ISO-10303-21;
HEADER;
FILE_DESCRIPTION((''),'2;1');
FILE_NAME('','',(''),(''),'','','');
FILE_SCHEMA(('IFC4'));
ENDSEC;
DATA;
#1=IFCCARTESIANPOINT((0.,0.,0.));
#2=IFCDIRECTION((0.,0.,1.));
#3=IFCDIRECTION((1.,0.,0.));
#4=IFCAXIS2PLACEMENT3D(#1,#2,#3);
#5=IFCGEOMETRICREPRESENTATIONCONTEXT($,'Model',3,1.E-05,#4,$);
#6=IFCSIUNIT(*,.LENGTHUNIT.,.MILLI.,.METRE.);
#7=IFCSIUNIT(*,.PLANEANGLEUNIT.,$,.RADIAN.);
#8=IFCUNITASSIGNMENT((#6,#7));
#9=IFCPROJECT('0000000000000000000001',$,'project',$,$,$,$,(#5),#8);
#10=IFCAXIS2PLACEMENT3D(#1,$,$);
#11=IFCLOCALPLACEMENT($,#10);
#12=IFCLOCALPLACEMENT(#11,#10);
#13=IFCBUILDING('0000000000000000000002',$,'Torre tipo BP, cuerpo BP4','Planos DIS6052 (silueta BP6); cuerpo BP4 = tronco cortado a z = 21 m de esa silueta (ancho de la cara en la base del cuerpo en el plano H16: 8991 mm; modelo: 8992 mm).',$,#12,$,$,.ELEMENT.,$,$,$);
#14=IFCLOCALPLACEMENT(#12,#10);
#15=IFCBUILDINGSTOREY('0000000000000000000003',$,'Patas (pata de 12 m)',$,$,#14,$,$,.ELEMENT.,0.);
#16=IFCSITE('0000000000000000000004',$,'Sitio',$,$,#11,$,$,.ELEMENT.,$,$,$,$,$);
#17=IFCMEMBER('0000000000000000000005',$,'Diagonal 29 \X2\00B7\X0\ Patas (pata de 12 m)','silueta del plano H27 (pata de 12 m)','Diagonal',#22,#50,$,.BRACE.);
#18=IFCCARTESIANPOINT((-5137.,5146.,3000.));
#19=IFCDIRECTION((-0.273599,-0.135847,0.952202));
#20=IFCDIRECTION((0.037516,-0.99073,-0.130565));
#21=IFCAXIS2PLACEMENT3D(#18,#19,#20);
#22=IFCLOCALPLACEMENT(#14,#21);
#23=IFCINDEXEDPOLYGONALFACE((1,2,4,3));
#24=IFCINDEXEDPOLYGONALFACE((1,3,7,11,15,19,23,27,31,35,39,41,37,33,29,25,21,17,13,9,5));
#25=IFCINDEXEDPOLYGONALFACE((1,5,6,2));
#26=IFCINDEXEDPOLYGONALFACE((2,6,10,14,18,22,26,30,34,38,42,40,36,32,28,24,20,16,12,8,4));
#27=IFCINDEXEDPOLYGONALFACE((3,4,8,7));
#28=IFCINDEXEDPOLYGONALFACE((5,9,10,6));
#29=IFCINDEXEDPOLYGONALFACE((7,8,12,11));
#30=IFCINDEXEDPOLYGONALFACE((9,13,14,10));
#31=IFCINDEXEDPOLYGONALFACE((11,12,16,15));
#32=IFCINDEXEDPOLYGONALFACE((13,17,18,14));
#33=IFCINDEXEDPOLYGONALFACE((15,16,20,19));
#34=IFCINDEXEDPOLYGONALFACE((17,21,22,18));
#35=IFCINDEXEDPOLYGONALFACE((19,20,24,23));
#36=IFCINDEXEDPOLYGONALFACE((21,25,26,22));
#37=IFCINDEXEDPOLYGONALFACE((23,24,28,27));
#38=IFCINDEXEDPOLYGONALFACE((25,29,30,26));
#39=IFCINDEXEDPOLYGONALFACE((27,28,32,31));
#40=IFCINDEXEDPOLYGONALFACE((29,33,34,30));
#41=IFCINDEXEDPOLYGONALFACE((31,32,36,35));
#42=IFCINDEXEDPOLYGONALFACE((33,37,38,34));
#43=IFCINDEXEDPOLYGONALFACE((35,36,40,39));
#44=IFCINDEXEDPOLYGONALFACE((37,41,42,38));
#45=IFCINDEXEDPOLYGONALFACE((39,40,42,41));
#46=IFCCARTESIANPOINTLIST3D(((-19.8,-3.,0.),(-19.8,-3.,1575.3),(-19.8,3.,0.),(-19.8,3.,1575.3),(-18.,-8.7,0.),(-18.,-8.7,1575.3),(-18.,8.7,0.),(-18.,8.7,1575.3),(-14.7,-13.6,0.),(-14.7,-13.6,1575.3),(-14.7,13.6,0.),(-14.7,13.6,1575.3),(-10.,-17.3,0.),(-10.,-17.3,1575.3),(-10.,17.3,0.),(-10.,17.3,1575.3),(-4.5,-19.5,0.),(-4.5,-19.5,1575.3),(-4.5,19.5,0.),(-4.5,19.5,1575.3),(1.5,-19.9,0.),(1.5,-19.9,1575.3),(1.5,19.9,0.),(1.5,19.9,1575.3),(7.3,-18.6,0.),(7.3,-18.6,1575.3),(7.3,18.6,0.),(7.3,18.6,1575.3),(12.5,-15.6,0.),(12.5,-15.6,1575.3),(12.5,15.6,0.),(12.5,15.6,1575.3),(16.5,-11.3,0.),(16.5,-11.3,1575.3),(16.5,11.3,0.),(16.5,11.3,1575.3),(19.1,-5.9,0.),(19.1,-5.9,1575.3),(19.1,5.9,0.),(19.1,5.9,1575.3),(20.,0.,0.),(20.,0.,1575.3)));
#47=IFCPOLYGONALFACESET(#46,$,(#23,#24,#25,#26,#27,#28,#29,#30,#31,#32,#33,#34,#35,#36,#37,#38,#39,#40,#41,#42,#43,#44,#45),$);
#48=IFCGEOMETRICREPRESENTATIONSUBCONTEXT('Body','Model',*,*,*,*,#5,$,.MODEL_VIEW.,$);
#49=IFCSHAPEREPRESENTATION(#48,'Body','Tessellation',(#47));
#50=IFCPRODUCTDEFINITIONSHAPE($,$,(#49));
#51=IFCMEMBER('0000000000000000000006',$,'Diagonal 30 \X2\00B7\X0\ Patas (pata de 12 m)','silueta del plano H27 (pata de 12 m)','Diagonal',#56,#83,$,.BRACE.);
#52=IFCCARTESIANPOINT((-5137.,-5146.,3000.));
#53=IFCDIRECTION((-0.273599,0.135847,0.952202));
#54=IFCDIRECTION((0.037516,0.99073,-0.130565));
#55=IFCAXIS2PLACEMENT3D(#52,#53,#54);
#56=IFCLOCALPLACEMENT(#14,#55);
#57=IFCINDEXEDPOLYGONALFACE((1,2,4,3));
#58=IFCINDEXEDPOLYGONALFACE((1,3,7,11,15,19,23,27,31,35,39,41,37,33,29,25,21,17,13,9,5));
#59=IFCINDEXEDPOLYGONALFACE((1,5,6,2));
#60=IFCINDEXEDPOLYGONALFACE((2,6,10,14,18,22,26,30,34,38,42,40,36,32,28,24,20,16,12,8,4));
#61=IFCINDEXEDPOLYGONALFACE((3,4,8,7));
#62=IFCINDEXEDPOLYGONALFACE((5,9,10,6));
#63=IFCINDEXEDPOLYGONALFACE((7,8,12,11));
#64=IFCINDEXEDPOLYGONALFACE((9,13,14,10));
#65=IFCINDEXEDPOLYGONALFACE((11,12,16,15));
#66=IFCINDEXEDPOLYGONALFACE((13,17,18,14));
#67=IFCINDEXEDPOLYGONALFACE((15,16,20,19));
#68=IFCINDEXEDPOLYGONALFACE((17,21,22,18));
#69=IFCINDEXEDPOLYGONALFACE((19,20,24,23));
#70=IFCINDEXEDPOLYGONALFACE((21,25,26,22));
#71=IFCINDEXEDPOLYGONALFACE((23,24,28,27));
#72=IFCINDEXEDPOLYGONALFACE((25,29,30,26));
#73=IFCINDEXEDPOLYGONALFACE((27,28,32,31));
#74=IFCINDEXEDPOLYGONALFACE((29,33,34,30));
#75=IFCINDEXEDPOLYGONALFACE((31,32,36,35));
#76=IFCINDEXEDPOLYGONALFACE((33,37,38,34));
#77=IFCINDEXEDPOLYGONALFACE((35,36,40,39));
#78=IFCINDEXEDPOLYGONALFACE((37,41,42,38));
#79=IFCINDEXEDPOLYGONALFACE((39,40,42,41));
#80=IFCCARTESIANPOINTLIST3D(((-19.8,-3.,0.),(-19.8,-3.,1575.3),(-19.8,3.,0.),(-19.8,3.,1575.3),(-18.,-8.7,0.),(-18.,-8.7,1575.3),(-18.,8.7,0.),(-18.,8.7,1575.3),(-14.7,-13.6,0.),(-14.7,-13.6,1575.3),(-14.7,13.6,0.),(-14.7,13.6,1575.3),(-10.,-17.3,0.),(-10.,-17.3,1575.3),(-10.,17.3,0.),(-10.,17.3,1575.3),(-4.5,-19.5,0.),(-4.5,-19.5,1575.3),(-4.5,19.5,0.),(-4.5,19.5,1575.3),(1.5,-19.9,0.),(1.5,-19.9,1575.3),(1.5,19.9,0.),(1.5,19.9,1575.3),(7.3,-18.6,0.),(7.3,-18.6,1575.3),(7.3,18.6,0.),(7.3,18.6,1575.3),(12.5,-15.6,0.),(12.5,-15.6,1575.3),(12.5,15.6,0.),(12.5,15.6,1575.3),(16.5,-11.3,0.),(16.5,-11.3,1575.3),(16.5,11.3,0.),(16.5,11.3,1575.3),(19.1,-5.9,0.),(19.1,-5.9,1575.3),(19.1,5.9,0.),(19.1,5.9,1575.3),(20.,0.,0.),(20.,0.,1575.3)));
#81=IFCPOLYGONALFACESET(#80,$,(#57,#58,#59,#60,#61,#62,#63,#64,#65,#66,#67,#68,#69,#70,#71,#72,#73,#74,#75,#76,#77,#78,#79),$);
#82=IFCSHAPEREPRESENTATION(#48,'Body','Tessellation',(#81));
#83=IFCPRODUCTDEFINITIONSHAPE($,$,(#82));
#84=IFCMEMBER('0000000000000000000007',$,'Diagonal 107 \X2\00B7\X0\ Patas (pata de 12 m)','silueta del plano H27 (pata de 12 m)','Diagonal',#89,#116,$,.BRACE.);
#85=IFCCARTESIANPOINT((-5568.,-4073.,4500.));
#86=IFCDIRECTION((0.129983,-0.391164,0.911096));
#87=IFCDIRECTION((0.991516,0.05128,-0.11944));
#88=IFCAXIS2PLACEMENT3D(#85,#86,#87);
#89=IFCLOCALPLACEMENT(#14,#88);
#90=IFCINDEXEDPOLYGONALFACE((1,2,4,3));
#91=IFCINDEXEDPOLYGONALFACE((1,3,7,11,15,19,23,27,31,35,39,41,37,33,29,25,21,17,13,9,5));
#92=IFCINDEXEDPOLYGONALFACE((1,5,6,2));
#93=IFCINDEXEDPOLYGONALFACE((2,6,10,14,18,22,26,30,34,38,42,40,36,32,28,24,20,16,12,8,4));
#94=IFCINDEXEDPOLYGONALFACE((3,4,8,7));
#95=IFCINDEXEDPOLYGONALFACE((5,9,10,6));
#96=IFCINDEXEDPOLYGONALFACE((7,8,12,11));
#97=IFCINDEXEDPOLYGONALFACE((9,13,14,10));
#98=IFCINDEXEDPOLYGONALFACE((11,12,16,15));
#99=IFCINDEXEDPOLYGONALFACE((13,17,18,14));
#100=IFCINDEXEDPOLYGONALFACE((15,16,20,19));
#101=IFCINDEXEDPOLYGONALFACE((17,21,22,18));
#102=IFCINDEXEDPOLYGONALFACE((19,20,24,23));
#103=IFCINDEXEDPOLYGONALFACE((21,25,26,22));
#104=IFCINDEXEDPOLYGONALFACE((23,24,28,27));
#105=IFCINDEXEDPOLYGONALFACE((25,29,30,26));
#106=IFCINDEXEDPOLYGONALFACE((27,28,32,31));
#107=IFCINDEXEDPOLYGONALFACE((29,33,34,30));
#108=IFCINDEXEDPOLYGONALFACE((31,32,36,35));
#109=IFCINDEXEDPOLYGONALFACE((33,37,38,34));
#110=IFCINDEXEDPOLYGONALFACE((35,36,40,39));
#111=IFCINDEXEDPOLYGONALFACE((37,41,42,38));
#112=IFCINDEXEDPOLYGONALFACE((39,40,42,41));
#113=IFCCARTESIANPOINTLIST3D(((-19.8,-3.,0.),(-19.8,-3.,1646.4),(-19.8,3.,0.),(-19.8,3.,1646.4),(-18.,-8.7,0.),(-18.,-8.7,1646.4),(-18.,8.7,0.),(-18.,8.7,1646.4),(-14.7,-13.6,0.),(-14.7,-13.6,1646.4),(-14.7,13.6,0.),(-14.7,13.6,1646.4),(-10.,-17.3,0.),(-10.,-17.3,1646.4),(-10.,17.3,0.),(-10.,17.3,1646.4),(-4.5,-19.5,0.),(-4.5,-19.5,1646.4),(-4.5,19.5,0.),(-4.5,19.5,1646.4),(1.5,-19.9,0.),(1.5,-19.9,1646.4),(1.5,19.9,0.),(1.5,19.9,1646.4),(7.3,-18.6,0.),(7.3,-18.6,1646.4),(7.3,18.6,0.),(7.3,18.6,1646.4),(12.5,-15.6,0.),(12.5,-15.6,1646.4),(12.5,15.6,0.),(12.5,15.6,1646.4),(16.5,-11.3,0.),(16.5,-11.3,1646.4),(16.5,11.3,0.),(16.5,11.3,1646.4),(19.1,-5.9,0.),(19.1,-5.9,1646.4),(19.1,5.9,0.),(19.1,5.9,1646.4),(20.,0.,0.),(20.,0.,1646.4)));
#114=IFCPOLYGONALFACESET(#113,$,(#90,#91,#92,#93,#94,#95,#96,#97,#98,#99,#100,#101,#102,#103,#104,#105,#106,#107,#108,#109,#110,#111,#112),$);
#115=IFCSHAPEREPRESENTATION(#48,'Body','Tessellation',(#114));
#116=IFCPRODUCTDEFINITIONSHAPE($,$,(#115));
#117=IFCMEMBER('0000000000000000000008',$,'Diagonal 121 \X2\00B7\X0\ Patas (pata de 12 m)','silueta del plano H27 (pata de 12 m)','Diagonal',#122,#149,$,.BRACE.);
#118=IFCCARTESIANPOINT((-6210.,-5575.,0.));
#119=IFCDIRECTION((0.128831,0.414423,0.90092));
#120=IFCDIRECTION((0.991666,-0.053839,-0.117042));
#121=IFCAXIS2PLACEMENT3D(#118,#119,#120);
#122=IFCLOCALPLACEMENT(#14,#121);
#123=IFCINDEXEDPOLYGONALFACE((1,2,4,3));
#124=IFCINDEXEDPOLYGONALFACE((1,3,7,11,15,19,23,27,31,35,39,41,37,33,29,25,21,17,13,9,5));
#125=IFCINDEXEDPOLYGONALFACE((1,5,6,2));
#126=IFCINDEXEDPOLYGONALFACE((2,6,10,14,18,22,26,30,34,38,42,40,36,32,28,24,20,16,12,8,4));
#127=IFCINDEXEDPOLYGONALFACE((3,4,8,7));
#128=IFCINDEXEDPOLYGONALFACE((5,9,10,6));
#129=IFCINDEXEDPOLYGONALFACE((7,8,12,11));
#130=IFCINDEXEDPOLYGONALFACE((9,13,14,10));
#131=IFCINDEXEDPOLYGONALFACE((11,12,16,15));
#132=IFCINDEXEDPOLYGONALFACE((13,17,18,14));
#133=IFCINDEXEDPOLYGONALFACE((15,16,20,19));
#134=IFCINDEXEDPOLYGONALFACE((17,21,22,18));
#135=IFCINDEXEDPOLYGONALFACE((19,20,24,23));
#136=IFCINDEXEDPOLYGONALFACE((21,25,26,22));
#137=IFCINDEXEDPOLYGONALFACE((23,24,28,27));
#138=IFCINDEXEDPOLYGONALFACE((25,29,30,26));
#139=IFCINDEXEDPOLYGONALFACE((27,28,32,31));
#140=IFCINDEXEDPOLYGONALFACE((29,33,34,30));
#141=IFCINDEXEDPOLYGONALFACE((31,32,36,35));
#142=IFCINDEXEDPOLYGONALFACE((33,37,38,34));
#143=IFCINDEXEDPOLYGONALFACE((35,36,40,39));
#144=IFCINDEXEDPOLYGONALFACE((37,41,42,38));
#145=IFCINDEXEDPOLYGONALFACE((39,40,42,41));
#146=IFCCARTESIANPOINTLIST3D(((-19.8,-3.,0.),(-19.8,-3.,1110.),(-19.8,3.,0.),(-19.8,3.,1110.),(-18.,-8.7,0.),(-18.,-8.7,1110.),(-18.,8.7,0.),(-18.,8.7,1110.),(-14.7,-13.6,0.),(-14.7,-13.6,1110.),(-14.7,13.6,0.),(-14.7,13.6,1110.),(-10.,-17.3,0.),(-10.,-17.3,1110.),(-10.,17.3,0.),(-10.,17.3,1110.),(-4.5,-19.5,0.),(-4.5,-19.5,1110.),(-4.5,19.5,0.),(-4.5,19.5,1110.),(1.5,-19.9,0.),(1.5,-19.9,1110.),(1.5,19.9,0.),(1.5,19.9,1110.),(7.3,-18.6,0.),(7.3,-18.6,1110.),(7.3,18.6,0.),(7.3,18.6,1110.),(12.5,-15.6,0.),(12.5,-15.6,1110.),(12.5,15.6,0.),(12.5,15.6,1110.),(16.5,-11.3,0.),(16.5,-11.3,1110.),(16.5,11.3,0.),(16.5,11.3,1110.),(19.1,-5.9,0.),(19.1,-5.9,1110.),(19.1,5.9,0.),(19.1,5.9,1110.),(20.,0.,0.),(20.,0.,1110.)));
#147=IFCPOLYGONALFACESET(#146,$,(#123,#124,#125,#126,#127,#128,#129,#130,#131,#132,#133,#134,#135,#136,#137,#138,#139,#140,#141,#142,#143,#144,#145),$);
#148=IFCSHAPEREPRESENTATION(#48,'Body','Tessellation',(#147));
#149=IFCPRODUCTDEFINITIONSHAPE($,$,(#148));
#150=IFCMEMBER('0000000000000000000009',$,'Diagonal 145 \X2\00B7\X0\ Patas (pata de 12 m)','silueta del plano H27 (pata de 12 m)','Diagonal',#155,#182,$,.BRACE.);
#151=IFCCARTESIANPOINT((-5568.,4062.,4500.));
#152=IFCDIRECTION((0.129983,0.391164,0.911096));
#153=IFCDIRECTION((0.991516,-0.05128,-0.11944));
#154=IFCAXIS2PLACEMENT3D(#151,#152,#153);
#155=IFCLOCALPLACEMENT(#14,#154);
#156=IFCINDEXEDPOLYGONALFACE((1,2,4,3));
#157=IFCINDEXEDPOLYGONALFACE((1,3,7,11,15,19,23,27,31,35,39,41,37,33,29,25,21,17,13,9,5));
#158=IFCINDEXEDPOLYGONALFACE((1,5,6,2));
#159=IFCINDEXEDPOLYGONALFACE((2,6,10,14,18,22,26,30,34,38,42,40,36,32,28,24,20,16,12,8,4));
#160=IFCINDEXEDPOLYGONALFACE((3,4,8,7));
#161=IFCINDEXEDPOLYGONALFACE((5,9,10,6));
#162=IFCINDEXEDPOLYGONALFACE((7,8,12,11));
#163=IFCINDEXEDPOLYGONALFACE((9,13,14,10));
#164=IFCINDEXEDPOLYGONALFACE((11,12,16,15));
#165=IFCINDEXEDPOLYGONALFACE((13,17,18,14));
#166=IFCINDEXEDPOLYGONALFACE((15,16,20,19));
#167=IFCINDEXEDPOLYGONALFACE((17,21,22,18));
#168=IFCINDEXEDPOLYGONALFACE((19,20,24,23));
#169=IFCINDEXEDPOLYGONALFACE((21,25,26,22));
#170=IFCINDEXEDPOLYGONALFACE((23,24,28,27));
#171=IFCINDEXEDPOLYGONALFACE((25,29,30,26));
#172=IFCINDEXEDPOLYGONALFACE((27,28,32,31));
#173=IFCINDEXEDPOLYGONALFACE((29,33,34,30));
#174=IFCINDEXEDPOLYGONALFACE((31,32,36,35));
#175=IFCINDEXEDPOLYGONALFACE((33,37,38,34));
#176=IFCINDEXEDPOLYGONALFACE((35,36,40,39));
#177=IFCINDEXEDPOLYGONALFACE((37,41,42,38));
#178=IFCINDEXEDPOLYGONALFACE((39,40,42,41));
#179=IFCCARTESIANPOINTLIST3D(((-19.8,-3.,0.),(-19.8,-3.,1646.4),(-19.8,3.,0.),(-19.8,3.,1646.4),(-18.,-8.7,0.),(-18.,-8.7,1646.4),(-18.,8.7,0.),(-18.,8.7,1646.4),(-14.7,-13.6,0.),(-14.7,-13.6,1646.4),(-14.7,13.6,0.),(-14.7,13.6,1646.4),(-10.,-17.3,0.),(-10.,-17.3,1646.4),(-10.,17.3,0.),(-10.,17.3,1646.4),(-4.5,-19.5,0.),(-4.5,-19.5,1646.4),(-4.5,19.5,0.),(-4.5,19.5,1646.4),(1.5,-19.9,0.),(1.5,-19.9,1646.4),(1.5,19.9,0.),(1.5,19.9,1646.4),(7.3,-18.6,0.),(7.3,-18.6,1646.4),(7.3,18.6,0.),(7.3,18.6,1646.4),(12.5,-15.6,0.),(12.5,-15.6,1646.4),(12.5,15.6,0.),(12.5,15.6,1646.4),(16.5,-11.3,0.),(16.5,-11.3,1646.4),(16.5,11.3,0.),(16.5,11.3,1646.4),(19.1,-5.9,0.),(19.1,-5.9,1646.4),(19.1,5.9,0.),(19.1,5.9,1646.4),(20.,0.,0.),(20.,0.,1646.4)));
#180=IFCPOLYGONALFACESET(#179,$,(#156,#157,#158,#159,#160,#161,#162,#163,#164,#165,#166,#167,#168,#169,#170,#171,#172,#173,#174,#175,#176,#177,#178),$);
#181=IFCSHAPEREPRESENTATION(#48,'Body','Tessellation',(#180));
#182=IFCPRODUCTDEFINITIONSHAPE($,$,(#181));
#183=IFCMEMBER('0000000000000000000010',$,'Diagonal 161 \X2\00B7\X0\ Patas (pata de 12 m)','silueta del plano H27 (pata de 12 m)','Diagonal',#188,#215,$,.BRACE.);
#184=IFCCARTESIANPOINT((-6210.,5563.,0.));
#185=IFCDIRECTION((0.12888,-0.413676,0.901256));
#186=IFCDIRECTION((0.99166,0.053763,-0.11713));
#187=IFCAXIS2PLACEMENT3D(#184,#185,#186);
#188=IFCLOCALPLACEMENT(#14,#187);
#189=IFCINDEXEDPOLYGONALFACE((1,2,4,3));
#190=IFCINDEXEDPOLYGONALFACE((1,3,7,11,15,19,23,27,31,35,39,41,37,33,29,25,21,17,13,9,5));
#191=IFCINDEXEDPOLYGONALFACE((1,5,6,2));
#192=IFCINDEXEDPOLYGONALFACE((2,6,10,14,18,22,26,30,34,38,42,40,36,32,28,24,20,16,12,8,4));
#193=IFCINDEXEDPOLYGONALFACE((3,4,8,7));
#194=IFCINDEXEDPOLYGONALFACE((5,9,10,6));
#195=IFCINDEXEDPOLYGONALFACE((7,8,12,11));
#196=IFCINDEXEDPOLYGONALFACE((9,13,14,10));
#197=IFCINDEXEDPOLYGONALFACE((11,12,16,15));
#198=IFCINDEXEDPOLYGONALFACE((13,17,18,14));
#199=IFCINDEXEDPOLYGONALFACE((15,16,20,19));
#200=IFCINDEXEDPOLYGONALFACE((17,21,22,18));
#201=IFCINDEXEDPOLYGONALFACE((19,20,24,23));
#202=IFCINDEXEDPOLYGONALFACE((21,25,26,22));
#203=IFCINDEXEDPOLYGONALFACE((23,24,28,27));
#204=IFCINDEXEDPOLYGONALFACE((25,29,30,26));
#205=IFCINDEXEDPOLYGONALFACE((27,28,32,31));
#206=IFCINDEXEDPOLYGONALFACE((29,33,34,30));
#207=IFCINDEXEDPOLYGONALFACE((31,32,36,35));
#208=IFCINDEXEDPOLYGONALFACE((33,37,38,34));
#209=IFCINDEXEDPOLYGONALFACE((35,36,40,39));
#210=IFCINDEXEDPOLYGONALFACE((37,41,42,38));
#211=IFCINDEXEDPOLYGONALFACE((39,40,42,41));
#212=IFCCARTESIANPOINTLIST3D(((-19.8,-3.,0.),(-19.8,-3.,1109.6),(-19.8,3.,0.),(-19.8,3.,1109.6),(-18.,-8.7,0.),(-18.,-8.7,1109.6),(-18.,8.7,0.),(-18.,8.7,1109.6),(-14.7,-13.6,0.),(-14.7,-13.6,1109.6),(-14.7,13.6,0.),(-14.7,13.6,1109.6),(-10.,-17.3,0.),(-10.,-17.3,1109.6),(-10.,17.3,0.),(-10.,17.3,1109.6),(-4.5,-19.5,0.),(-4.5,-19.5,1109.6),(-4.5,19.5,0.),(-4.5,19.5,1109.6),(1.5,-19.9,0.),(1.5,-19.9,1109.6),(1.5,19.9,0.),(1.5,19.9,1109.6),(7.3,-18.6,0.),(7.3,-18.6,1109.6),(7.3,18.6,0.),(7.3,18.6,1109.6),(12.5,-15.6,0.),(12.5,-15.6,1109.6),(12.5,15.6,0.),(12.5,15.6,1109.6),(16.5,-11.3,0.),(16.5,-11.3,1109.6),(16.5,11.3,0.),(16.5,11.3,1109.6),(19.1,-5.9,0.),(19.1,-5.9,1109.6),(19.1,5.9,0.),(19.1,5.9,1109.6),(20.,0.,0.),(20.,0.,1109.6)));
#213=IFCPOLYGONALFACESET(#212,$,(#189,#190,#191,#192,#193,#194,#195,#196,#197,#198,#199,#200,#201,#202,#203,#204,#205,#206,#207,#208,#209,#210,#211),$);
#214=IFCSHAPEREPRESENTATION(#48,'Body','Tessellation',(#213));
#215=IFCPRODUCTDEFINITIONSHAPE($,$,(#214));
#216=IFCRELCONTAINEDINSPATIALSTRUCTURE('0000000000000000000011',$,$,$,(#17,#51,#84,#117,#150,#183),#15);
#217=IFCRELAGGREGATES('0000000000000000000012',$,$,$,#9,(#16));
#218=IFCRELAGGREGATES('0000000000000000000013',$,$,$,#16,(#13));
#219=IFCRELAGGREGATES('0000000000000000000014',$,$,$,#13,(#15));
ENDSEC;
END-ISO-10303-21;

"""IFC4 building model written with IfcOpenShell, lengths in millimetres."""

from ifc_helpers import new_model, si_unit, frame, origin, origin_with_axes, place, context, subcontext, project, spatial, circle, extrude, element, save


model = new_model("IFC4")

# Units and contexts
model_context = context("Model", 3, precision=1e-05, world=origin_with_axes())
body_context = subcontext(model_context, "Body", "Model", "MODEL_VIEW")
ifc_project = project(units=[si_unit("LENGTHUNIT", "METRE", prefix="MILLI"), si_unit("PLANEANGLEUNIT", "RADIAN")], contexts=[model_context])

# Site, building, storey
site_placement = place(None, origin())
site = spatial("IfcSite", under=ifc_project, at=site_placement, Name="Sitio", CompositionType="ELEMENT")
building_placement = place(site_placement, origin())
building = spatial("IfcBuilding", under=site, at=building_placement, Name="Torre tipo BP, cuerpo BP4", Description="Planos DIS6052 (silueta BP6); cuerpo BP4 = tronco cortado a z = 21 m de esa silueta (ancho de la cara en la base del cuerpo en el plano H16: 8991 mm; modelo: 8992 mm).", CompositionType="ELEMENT")
storey_placement = place(building_placement, origin())
storey = spatial("IfcBuildingStorey", under=building, at=storey_placement, Name="Patas (pata de 12 m)", CompositionType="ELEMENT", Elevation=0.0)

# Members
for number, where, z_axis, x_axis, name in (
    (1, (-5137.0, 5146.0, 3000.0), (-0.273599, -0.135847, 0.952202), (0.037516, -0.99073, -0.130565), "Diagonal 29 · Patas (pata de 12 m)"),
    (2, (-5137.0, -5146.0, 3000.0), (-0.273599, 0.135847, 0.952202), (0.037516, 0.99073, -0.130565), "Diagonal 30 · Patas (pata de 12 m)"),
):
    element("IfcMember", number, at=place(storey_placement, frame(where, z_axis=z_axis, x_axis=x_axis)), inside=storey, Name=name, Description="silueta del plano H27 (pata de 12 m)", ObjectType="Diagonal", PredefinedType="BRACE", context=body_context, shape_type="SweptSolid", body=[
        extrude(circle(Radius=20.0), None, (0.0, 0.0, 1.0), 1575.3),
    ])
member_1_placement = place(storey_placement, frame((-5568.0, -4073.0, 4500.0), z_axis=(0.129983, -0.391164, 0.911096), x_axis=(0.991516, 0.05128, -0.11944)))
element("IfcMember", 3, at=member_1_placement, inside=storey, Name="Diagonal 107 · Patas (pata de 12 m)", Description="silueta del plano H27 (pata de 12 m)", ObjectType="Diagonal", PredefinedType="BRACE", context=body_context, shape_type="SweptSolid", body=[
    extrude(circle(Radius=20.0), None, (0.0, 0.0, 1.0), 1646.4),
])
member_2_placement = place(storey_placement, frame((-6210.0, -5575.0, 0.0), z_axis=(0.128831, 0.414423, 0.90092), x_axis=(0.991666, -0.053839, -0.117042)))
element("IfcMember", 4, at=member_2_placement, inside=storey, Name="Diagonal 121 · Patas (pata de 12 m)", Description="silueta del plano H27 (pata de 12 m)", ObjectType="Diagonal", PredefinedType="BRACE", context=body_context, shape_type="SweptSolid", body=[
    extrude(circle(Radius=20.0), None, (0.0, 0.0, 1.0), 1110.0),
])
member_3_placement = place(storey_placement, frame((-5568.0, 4062.0, 4500.0), z_axis=(0.129983, 0.391164, 0.911096), x_axis=(0.991516, -0.05128, -0.11944)))
element("IfcMember", 5, at=member_3_placement, inside=storey, Name="Diagonal 145 · Patas (pata de 12 m)", Description="silueta del plano H27 (pata de 12 m)", ObjectType="Diagonal", PredefinedType="BRACE", context=body_context, shape_type="SweptSolid", body=[
    extrude(circle(Radius=20.0), None, (0.0, 0.0, 1.0), 1646.4),
])
member_4_placement = place(storey_placement, frame((-6210.0, 5563.0, 0.0), z_axis=(0.12888, -0.413676, 0.901256), x_axis=(0.99166, 0.053763, -0.11713)))
element("IfcMember", 6, at=member_4_placement, inside=storey, Name="Diagonal 161 · Patas (pata de 12 m)", Description="silueta del plano H27 (pata de 12 m)", ObjectType="Diagonal", PredefinedType="BRACE", context=body_context, shape_type="SweptSolid", body=[
    extrude(circle(Radius=20.0), None, (0.0, 0.0, 1.0), 1109.6),
])

save(model, "model.ifc")
